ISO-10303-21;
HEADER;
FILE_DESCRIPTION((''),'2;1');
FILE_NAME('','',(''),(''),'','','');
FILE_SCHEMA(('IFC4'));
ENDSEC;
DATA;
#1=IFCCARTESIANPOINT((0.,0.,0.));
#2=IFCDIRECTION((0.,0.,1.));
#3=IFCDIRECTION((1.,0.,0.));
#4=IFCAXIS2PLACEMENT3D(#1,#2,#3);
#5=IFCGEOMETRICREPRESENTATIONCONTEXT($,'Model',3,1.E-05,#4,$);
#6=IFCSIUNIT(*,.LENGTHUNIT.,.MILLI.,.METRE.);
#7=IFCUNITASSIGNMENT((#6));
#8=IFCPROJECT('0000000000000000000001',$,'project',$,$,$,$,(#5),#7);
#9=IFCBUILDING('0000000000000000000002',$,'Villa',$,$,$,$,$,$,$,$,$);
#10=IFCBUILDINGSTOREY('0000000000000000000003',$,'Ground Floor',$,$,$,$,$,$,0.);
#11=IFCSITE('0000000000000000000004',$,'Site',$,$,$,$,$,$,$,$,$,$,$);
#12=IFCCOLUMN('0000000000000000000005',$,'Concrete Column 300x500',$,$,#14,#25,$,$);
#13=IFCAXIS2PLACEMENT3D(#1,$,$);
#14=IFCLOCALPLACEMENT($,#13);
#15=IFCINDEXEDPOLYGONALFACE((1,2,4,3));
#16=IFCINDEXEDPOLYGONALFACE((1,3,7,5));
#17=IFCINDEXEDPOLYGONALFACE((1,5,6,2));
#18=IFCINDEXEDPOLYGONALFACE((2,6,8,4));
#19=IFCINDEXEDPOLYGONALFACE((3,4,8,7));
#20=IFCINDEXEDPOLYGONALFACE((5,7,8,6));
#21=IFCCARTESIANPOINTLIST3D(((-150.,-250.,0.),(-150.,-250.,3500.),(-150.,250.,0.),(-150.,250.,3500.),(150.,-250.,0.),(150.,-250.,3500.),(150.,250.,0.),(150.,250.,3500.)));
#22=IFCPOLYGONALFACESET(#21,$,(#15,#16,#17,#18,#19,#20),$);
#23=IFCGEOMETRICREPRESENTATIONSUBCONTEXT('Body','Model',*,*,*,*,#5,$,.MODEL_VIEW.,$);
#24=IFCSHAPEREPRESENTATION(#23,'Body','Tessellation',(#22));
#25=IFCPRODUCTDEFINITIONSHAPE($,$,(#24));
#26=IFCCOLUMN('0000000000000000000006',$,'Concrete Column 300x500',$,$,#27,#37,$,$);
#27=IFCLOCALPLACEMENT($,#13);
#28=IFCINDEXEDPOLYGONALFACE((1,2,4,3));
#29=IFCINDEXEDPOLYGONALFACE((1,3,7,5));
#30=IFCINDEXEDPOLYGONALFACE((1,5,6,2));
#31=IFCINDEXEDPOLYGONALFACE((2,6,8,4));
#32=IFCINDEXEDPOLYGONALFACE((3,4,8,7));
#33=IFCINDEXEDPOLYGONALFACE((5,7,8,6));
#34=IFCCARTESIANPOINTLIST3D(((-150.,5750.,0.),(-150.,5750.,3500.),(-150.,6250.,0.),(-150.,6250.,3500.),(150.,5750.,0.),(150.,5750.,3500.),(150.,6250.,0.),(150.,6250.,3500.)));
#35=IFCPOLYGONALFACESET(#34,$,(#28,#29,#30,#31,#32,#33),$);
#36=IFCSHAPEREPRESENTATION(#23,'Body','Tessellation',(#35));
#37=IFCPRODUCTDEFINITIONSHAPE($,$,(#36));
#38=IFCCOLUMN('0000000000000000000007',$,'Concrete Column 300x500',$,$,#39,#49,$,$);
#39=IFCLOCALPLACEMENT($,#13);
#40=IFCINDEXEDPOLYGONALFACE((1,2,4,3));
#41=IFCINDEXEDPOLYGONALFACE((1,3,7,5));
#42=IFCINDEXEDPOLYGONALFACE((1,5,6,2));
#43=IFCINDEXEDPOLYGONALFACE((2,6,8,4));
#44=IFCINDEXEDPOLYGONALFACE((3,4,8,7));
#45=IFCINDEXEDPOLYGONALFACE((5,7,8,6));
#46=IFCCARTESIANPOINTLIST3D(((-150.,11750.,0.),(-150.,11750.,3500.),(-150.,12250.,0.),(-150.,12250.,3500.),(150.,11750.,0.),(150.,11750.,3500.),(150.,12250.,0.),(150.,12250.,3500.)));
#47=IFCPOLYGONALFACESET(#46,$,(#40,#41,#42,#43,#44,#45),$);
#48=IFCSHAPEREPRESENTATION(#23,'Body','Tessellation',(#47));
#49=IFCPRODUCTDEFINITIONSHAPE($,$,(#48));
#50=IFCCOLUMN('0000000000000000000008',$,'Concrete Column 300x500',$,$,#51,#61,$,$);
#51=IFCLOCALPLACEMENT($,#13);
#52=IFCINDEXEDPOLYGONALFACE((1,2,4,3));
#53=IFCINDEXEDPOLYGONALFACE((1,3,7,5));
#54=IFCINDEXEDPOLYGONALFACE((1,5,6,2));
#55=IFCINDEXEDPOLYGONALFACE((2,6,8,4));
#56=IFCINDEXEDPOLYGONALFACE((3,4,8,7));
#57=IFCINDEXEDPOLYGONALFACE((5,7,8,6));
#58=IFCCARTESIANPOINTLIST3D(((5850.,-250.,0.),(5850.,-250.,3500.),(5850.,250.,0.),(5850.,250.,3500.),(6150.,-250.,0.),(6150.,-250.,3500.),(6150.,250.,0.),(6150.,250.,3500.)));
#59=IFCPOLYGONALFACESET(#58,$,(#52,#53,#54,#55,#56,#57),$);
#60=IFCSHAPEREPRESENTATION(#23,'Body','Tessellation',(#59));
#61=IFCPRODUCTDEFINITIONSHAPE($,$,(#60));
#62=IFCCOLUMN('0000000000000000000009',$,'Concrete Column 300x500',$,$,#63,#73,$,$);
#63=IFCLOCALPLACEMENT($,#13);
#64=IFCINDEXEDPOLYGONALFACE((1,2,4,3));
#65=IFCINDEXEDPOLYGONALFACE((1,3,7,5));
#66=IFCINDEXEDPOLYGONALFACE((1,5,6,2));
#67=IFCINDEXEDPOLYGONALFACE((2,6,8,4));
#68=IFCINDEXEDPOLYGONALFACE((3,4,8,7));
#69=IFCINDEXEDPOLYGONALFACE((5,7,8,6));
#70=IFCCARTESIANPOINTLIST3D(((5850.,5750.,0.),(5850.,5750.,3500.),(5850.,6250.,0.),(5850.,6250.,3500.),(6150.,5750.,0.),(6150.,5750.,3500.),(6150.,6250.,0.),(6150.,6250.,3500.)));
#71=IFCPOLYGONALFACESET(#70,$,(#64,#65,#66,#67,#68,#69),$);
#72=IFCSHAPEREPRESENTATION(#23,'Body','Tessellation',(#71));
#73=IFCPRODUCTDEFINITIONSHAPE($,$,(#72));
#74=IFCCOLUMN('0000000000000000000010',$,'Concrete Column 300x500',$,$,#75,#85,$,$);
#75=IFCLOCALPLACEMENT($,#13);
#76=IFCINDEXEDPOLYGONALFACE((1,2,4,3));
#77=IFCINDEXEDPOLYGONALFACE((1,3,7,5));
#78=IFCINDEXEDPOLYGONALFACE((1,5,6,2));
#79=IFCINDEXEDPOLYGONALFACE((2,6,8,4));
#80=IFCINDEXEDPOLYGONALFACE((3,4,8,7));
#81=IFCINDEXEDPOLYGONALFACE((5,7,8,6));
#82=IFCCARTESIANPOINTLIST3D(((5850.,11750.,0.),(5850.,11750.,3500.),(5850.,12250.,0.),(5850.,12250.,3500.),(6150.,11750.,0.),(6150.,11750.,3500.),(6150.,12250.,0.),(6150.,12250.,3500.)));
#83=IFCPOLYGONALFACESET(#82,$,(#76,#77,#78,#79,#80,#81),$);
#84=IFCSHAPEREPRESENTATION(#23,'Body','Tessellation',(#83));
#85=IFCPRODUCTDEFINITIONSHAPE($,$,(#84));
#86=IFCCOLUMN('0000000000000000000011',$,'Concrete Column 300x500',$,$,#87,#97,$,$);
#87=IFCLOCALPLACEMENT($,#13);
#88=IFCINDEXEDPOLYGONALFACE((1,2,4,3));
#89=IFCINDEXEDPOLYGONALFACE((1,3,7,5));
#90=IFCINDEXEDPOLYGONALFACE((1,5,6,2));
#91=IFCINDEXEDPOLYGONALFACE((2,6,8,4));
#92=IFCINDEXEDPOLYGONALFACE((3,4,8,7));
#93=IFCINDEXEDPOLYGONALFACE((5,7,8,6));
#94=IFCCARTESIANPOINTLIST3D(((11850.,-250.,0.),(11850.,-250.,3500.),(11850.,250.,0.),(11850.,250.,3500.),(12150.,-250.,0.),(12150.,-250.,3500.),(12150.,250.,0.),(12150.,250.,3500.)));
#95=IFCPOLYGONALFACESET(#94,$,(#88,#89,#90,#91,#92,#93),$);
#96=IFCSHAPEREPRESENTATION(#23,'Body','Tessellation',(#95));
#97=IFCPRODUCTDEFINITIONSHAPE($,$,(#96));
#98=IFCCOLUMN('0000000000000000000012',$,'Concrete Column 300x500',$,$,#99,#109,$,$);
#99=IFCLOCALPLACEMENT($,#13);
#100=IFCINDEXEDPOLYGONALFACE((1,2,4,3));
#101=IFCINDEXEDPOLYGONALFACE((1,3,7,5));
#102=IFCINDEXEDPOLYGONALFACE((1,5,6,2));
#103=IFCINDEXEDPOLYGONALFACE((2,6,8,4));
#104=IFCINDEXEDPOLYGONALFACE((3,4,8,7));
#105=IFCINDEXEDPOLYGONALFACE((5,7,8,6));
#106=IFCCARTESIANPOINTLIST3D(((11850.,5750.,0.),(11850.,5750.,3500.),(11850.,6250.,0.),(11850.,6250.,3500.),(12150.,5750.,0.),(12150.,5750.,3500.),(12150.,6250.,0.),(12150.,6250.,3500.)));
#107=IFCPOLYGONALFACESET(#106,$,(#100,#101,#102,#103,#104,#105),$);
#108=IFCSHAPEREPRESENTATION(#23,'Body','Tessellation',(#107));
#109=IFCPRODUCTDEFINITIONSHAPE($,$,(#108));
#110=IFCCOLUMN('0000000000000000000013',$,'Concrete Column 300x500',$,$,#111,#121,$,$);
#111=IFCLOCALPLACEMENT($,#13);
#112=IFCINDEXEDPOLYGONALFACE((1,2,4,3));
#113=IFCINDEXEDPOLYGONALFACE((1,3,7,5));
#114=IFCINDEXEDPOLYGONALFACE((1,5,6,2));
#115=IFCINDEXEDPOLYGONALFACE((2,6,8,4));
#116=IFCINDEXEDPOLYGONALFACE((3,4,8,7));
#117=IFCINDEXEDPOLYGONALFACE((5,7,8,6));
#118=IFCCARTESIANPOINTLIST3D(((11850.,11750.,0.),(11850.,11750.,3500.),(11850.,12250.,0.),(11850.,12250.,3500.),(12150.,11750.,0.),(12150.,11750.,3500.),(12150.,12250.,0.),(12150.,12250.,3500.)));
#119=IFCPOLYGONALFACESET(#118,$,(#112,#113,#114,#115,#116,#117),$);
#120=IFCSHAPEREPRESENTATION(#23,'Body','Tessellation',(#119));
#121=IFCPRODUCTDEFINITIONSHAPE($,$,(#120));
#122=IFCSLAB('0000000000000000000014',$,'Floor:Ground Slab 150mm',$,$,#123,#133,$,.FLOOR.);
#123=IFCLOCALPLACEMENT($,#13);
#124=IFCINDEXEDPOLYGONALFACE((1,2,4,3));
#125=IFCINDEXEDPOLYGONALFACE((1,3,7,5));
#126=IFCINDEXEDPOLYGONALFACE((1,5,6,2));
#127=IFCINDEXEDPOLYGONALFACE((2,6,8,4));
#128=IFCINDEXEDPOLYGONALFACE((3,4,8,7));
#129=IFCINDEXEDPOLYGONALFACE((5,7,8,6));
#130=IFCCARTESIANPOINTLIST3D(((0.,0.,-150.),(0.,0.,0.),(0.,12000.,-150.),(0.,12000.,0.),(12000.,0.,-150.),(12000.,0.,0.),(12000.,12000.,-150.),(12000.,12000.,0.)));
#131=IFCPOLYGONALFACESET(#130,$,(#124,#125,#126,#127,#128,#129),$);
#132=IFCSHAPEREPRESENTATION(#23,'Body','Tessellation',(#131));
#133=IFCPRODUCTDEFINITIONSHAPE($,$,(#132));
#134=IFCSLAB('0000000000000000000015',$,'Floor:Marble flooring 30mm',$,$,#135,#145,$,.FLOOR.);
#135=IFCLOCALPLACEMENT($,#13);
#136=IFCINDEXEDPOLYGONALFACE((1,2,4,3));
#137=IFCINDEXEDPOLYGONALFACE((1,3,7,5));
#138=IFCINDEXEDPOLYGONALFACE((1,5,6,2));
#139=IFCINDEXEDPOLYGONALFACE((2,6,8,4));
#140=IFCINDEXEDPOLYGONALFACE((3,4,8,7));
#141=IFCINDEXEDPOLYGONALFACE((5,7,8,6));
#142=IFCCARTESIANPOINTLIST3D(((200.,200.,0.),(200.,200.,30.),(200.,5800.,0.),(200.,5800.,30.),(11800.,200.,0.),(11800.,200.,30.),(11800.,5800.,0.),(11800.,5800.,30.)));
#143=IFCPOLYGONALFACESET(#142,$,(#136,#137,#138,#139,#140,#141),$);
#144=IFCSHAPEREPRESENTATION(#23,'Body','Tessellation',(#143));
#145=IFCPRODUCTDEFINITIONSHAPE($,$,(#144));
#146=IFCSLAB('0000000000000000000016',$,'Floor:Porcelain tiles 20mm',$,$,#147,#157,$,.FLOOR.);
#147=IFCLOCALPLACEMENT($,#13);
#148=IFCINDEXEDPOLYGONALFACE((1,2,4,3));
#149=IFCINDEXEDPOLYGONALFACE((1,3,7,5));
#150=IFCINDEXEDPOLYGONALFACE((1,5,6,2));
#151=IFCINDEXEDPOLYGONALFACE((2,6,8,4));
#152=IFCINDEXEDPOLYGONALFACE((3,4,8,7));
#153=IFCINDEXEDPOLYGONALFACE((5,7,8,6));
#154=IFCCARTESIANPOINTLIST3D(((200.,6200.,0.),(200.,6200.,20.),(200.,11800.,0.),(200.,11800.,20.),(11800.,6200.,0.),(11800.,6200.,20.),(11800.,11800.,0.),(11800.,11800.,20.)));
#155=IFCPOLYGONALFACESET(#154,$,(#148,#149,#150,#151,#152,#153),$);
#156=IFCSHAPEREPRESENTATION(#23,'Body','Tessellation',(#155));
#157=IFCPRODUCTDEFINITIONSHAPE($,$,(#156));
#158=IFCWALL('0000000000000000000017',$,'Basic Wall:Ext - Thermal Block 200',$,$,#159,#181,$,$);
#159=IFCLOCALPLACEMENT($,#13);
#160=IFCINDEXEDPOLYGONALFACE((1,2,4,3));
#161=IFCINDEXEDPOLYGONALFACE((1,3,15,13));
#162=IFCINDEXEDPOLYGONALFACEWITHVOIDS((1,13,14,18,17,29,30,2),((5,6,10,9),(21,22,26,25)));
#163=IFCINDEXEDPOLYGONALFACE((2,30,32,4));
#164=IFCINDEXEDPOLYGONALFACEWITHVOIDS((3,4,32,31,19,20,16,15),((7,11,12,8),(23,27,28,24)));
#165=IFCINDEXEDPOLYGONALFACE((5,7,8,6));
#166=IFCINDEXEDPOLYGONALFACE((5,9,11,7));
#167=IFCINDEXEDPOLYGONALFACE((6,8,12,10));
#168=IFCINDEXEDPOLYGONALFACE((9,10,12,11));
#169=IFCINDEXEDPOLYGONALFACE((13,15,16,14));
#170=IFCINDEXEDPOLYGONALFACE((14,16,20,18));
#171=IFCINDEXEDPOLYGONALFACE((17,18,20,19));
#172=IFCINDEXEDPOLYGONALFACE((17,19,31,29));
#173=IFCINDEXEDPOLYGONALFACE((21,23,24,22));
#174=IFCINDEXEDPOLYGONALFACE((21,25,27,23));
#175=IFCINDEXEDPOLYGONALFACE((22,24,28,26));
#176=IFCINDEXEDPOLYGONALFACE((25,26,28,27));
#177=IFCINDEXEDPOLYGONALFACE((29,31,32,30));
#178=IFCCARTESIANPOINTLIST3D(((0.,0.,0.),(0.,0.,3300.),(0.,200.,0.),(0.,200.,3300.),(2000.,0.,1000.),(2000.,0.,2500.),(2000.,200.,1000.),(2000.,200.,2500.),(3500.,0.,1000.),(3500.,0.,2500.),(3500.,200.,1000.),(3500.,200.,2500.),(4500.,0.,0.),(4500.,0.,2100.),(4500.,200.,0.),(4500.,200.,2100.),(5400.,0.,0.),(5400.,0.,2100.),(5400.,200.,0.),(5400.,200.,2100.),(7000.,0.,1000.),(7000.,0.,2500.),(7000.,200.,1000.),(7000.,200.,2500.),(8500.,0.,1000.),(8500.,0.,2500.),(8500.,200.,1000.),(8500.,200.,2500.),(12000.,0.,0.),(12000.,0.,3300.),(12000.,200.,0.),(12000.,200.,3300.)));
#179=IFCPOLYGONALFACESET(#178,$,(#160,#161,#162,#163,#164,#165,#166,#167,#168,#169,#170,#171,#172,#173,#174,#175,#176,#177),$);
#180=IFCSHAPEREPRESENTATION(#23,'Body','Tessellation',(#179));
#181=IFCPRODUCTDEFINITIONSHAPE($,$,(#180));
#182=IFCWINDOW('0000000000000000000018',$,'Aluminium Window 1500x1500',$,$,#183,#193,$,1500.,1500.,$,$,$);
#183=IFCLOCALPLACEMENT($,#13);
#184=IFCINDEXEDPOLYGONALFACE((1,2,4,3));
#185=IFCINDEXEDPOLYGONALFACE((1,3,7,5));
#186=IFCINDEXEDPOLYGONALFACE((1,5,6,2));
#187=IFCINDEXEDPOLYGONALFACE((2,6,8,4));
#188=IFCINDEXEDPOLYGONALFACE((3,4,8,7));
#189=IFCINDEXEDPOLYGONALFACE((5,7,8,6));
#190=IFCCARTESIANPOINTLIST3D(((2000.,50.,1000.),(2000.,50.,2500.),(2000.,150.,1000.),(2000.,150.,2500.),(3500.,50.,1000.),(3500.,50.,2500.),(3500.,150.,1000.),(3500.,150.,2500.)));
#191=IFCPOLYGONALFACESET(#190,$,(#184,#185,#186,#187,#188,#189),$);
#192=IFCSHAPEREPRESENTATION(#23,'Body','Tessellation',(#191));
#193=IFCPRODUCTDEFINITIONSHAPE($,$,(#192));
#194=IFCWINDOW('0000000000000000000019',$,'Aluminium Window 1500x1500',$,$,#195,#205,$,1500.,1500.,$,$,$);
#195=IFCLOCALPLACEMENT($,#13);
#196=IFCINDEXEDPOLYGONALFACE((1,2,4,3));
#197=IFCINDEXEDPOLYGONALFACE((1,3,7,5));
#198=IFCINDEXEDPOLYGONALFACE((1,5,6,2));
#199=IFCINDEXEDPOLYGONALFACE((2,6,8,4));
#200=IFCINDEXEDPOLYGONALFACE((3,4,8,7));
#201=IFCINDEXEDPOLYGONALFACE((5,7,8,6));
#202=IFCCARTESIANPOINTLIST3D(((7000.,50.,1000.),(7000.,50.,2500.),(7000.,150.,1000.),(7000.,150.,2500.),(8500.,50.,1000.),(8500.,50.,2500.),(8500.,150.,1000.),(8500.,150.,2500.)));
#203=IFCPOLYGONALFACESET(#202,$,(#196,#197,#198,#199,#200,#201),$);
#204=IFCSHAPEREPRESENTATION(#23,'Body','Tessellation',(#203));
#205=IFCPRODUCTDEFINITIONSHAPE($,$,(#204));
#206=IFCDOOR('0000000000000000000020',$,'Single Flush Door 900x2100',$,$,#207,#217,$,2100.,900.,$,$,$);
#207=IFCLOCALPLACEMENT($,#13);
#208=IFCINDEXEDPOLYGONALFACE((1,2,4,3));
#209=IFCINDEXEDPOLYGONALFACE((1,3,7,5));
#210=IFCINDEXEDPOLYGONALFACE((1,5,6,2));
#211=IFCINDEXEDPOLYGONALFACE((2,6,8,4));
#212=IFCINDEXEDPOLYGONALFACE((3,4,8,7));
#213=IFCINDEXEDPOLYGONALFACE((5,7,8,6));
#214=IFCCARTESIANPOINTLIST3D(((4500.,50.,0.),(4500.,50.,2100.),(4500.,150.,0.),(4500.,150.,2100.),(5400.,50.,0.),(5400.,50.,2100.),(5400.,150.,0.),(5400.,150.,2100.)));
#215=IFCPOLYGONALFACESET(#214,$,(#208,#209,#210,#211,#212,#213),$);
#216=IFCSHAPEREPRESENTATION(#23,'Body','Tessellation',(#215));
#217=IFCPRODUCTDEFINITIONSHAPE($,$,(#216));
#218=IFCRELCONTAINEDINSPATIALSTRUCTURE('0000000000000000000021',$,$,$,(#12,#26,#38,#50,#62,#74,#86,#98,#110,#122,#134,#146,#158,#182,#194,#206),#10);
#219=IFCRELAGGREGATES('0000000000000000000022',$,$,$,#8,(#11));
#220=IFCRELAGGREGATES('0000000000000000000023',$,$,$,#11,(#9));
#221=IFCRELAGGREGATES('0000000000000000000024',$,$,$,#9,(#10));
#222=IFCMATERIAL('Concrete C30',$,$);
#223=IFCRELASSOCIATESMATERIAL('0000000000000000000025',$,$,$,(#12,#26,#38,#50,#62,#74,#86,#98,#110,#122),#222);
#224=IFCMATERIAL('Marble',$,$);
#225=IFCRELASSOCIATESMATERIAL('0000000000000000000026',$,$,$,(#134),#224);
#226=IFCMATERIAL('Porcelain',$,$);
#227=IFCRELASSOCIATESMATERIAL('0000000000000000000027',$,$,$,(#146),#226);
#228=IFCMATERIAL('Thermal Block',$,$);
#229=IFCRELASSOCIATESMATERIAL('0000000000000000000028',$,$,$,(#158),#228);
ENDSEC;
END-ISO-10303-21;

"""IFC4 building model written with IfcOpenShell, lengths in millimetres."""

from ifc_helpers import new_model, si_unit, frame, origin_with_axes, place, context, subcontext, project, spatial, indexed_curve, outline, extrude, material, element, fill, save


model = new_model("IFC4")

# Units and contexts
model_context = context("Model", 3, precision=1e-05, world=origin_with_axes())
body_context = subcontext(model_context, "Body", "Model", "MODEL_VIEW")
ifc_project = project(units=[si_unit("LENGTHUNIT", "METRE", prefix="MILLI")], contexts=[model_context])

# Site, building, storey
site = spatial("IfcSite", under=ifc_project, Name="Site")
building = spatial("IfcBuilding", under=site, Name="Villa")
storey = spatial("IfcBuildingStorey", under=building, Name="Ground Floor", Elevation=0.0)

# Columns
ifc_material_1 = material(Name="Concrete C30")
for number, where, z_axis, x_axis, name in (
    (1, (-150.0, -250.0, 0.0), (0.0, 0.0, 1.0), (1.0, 0.0, 0.0), "Concrete Column 300x500"),
    (2, (-150.0, 5750.0, 0.0), (0.0, 0.0, 1.0), (1.0, 0.0, 0.0), "Concrete Column 300x500"),
    (3, (-150.0, 11750.0, 0.0), (0.0, 0.0, 1.0), (1.0, 0.0, 0.0), "Concrete Column 300x500"),
    (4, (5850.0, -250.0, 0.0), (0.0, 0.0, 1.0), (1.0, 0.0, 0.0), "Concrete Column 300x500"),
    (5, (5850.0, 5750.0, 0.0), (0.0, 0.0, 1.0), (1.0, 0.0, 0.0), "Concrete Column 300x500"),
    (6, (5850.0, 11750.0, 0.0), (0.0, 0.0, 1.0), (1.0, 0.0, 0.0), "Concrete Column 300x500"),
    (7, (11850.0, -250.0, 0.0), (0.0, 0.0, 1.0), (1.0, 0.0, 0.0), "Concrete Column 300x500"),
    (8, (11850.0, 5750.0, 0.0), (0.0, 0.0, 1.0), (1.0, 0.0, 0.0), "Concrete Column 300x500"),
    (9, (11850.0, 11750.0, 0.0), (0.0, 0.0, 1.0), (1.0, 0.0, 0.0), "Concrete Column 300x500"),
):
    element("IfcColumn", number, at=place(None, frame(where, z_axis=z_axis, x_axis=x_axis)), inside=storey, material=ifc_material_1, Name=name, context=body_context, shape_type="SweptSolid", body=[
        extrude(outline(indexed_curve([(0.0, 0.0), (0.0, 500.0), (300.0, 500.0), (300.0, 0.0), (0.0, 0.0)], self_intersect=False)), origin_with_axes(), (0.0, 0.0, 1.0), 3500.0),
    ])

# Slabs
slab_1_placement = place(None, frame((0.0, 0.0, -150.0), z_axis=(0.0, 0.0, 1.0), x_axis=(1.0, 0.0, 0.0)))
element("IfcSlab", 10, at=slab_1_placement, inside=storey, material=ifc_material_1, Name="Floor:Ground Slab 150mm", PredefinedType="FLOOR", context=body_context, shape_type="SweptSolid", body=[
    extrude(outline(indexed_curve([(0.0, 0.0), (12000.0, 0.0), (12000.0, 12000.0), (0.0, 12000.0)])), None, (0.0, 0.0, 1.0), 150.0),
])
ifc_material_2 = material(Name="Marble")
slab_2_placement = place(None, frame((200.0, 200.0, 0.0), z_axis=(0.0, 0.0, 1.0), x_axis=(1.0, 0.0, 0.0)))
element("IfcSlab", 11, at=slab_2_placement, inside=storey, material=ifc_material_2, Name="Floor:Marble flooring 30mm", PredefinedType="FLOOR", context=body_context, shape_type="SweptSolid", body=[
    extrude(outline(indexed_curve([(0.0, 0.0), (11600.0, 0.0), (11600.0, 5600.0), (0.0, 5600.0)])), None, (0.0, 0.0, 1.0), 30.0),
])
ifc_material_3 = material(Name="Porcelain")
slab_3_placement = place(None, frame((200.0, 6200.0, 0.0), z_axis=(0.0, 0.0, 1.0), x_axis=(1.0, 0.0, 0.0)))
element("IfcSlab", 12, at=slab_3_placement, inside=storey, material=ifc_material_3, Name="Floor:Porcelain tiles 20mm", PredefinedType="FLOOR", context=body_context, shape_type="SweptSolid", body=[
    extrude(outline(indexed_curve([(0.0, 0.0), (11600.0, 0.0), (11600.0, 5600.0), (0.0, 5600.0)])), None, (0.0, 0.0, 1.0), 20.0),
])

# Wall, openings, windows, door
ifc_material_4 = material(Name="Thermal Block")
wall_1_placement = place(None, origin_with_axes())
wall_1 = element("IfcWall", 13, at=wall_1_placement, inside=storey, material=ifc_material_4, Name="Basic Wall:Ext - Thermal Block 200", context=body_context, shape_type="SweptSolid", body=[
    extrude(outline(indexed_curve([(0.0, 0.0), (0.0, 200.0), (12000.0, 200.0), (12000.0, 0.0), (0.0, 0.0)], self_intersect=False)), origin_with_axes(), (0.0, 0.0, 1.0), 3300.0),
])
opening_1_placement = place(wall_1_placement, frame((2000.0, -200.0, 1000.0), z_axis=(0.0, 0.0, 1.0), x_axis=(1.0, 0.0, 0.0)))
opening_1 = element("IfcOpeningElement", 14, at=opening_1_placement, cuts=wall_1, context=body_context, shape_type="SweptSolid", body=[
    extrude(outline(indexed_curve([(0.0, 0.0), (0.0, 600.0), (1500.0, 600.0), (1500.0, 0.0), (0.0, 0.0)], self_intersect=False)), origin_with_axes(), (0.0, 0.0, 1.0), 1500.0),
])
opening_2_placement = place(wall_1_placement, frame((7000.0, -200.0, 1000.0), z_axis=(0.0, 0.0, 1.0), x_axis=(1.0, 0.0, 0.0)))
opening_2 = element("IfcOpeningElement", 15, at=opening_2_placement, cuts=wall_1, context=body_context, shape_type="SweptSolid", body=[
    extrude(outline(indexed_curve([(0.0, 0.0), (0.0, 600.0), (1500.0, 600.0), (1500.0, 0.0), (0.0, 0.0)], self_intersect=False)), origin_with_axes(), (0.0, 0.0, 1.0), 1500.0),
])
opening_3_placement = place(wall_1_placement, frame((4500.0, -200.0, 0.0), z_axis=(0.0, 0.0, 1.0), x_axis=(1.0, 0.0, 0.0)))
opening_3 = element("IfcOpeningElement", 16, at=opening_3_placement, cuts=wall_1, context=body_context, shape_type="SweptSolid", body=[
    extrude(outline(indexed_curve([(0.0, 0.0), (0.0, 600.0), (900.0, 600.0), (900.0, 0.0), (0.0, 0.0)], self_intersect=False)), origin_with_axes(), (0.0, 0.0, 1.0), 2100.0),
])
window_1_placement = place(None, frame((2000.0, 50.0, 1000.0), z_axis=(0.0, 0.0, 1.0), x_axis=(1.0, 0.0, 0.0)))
window_1 = element("IfcWindow", 17, at=window_1_placement, inside=storey, Name="Aluminium Window 1500x1500", OverallHeight=1500.0, OverallWidth=1500.0, context=body_context, shape_type="SweptSolid", body=[
    extrude(outline(indexed_curve([(0.0, 0.0), (0.0, 100.0), (1500.0, 100.0), (1500.0, 0.0), (0.0, 0.0)], self_intersect=False)), origin_with_axes(), (0.0, 0.0, 1.0), 1500.0),
])
fill(opening_1, window_1)
window_2_placement = place(None, frame((7000.0, 50.0, 1000.0), z_axis=(0.0, 0.0, 1.0), x_axis=(1.0, 0.0, 0.0)))
window_2 = element("IfcWindow", 18, at=window_2_placement, inside=storey, Name="Aluminium Window 1500x1500", OverallHeight=1500.0, OverallWidth=1500.0, context=body_context, shape_type="SweptSolid", body=[
    extrude(outline(indexed_curve([(0.0, 0.0), (0.0, 100.0), (1500.0, 100.0), (1500.0, 0.0), (0.0, 0.0)], self_intersect=False)), origin_with_axes(), (0.0, 0.0, 1.0), 1500.0),
])
fill(opening_2, window_2)
door_placement = place(None, frame((4500.0, 50.0, 0.0), z_axis=(0.0, 0.0, 1.0), x_axis=(1.0, 0.0, 0.0)))
door = element("IfcDoor", 19, at=door_placement, inside=storey, Name="Single Flush Door 900x2100", OverallHeight=2100.0, OverallWidth=900.0, context=body_context, shape_type="SweptSolid", body=[
    extrude(outline(indexed_curve([(0.0, 0.0), (0.0, 100.0), (900.0, 100.0), (900.0, 0.0), (0.0, 0.0)], self_intersect=False)), origin_with_axes(), (0.0, 0.0, 1.0), 2100.0),
])
fill(opening_3, door)

save(model, "model.ifc")
